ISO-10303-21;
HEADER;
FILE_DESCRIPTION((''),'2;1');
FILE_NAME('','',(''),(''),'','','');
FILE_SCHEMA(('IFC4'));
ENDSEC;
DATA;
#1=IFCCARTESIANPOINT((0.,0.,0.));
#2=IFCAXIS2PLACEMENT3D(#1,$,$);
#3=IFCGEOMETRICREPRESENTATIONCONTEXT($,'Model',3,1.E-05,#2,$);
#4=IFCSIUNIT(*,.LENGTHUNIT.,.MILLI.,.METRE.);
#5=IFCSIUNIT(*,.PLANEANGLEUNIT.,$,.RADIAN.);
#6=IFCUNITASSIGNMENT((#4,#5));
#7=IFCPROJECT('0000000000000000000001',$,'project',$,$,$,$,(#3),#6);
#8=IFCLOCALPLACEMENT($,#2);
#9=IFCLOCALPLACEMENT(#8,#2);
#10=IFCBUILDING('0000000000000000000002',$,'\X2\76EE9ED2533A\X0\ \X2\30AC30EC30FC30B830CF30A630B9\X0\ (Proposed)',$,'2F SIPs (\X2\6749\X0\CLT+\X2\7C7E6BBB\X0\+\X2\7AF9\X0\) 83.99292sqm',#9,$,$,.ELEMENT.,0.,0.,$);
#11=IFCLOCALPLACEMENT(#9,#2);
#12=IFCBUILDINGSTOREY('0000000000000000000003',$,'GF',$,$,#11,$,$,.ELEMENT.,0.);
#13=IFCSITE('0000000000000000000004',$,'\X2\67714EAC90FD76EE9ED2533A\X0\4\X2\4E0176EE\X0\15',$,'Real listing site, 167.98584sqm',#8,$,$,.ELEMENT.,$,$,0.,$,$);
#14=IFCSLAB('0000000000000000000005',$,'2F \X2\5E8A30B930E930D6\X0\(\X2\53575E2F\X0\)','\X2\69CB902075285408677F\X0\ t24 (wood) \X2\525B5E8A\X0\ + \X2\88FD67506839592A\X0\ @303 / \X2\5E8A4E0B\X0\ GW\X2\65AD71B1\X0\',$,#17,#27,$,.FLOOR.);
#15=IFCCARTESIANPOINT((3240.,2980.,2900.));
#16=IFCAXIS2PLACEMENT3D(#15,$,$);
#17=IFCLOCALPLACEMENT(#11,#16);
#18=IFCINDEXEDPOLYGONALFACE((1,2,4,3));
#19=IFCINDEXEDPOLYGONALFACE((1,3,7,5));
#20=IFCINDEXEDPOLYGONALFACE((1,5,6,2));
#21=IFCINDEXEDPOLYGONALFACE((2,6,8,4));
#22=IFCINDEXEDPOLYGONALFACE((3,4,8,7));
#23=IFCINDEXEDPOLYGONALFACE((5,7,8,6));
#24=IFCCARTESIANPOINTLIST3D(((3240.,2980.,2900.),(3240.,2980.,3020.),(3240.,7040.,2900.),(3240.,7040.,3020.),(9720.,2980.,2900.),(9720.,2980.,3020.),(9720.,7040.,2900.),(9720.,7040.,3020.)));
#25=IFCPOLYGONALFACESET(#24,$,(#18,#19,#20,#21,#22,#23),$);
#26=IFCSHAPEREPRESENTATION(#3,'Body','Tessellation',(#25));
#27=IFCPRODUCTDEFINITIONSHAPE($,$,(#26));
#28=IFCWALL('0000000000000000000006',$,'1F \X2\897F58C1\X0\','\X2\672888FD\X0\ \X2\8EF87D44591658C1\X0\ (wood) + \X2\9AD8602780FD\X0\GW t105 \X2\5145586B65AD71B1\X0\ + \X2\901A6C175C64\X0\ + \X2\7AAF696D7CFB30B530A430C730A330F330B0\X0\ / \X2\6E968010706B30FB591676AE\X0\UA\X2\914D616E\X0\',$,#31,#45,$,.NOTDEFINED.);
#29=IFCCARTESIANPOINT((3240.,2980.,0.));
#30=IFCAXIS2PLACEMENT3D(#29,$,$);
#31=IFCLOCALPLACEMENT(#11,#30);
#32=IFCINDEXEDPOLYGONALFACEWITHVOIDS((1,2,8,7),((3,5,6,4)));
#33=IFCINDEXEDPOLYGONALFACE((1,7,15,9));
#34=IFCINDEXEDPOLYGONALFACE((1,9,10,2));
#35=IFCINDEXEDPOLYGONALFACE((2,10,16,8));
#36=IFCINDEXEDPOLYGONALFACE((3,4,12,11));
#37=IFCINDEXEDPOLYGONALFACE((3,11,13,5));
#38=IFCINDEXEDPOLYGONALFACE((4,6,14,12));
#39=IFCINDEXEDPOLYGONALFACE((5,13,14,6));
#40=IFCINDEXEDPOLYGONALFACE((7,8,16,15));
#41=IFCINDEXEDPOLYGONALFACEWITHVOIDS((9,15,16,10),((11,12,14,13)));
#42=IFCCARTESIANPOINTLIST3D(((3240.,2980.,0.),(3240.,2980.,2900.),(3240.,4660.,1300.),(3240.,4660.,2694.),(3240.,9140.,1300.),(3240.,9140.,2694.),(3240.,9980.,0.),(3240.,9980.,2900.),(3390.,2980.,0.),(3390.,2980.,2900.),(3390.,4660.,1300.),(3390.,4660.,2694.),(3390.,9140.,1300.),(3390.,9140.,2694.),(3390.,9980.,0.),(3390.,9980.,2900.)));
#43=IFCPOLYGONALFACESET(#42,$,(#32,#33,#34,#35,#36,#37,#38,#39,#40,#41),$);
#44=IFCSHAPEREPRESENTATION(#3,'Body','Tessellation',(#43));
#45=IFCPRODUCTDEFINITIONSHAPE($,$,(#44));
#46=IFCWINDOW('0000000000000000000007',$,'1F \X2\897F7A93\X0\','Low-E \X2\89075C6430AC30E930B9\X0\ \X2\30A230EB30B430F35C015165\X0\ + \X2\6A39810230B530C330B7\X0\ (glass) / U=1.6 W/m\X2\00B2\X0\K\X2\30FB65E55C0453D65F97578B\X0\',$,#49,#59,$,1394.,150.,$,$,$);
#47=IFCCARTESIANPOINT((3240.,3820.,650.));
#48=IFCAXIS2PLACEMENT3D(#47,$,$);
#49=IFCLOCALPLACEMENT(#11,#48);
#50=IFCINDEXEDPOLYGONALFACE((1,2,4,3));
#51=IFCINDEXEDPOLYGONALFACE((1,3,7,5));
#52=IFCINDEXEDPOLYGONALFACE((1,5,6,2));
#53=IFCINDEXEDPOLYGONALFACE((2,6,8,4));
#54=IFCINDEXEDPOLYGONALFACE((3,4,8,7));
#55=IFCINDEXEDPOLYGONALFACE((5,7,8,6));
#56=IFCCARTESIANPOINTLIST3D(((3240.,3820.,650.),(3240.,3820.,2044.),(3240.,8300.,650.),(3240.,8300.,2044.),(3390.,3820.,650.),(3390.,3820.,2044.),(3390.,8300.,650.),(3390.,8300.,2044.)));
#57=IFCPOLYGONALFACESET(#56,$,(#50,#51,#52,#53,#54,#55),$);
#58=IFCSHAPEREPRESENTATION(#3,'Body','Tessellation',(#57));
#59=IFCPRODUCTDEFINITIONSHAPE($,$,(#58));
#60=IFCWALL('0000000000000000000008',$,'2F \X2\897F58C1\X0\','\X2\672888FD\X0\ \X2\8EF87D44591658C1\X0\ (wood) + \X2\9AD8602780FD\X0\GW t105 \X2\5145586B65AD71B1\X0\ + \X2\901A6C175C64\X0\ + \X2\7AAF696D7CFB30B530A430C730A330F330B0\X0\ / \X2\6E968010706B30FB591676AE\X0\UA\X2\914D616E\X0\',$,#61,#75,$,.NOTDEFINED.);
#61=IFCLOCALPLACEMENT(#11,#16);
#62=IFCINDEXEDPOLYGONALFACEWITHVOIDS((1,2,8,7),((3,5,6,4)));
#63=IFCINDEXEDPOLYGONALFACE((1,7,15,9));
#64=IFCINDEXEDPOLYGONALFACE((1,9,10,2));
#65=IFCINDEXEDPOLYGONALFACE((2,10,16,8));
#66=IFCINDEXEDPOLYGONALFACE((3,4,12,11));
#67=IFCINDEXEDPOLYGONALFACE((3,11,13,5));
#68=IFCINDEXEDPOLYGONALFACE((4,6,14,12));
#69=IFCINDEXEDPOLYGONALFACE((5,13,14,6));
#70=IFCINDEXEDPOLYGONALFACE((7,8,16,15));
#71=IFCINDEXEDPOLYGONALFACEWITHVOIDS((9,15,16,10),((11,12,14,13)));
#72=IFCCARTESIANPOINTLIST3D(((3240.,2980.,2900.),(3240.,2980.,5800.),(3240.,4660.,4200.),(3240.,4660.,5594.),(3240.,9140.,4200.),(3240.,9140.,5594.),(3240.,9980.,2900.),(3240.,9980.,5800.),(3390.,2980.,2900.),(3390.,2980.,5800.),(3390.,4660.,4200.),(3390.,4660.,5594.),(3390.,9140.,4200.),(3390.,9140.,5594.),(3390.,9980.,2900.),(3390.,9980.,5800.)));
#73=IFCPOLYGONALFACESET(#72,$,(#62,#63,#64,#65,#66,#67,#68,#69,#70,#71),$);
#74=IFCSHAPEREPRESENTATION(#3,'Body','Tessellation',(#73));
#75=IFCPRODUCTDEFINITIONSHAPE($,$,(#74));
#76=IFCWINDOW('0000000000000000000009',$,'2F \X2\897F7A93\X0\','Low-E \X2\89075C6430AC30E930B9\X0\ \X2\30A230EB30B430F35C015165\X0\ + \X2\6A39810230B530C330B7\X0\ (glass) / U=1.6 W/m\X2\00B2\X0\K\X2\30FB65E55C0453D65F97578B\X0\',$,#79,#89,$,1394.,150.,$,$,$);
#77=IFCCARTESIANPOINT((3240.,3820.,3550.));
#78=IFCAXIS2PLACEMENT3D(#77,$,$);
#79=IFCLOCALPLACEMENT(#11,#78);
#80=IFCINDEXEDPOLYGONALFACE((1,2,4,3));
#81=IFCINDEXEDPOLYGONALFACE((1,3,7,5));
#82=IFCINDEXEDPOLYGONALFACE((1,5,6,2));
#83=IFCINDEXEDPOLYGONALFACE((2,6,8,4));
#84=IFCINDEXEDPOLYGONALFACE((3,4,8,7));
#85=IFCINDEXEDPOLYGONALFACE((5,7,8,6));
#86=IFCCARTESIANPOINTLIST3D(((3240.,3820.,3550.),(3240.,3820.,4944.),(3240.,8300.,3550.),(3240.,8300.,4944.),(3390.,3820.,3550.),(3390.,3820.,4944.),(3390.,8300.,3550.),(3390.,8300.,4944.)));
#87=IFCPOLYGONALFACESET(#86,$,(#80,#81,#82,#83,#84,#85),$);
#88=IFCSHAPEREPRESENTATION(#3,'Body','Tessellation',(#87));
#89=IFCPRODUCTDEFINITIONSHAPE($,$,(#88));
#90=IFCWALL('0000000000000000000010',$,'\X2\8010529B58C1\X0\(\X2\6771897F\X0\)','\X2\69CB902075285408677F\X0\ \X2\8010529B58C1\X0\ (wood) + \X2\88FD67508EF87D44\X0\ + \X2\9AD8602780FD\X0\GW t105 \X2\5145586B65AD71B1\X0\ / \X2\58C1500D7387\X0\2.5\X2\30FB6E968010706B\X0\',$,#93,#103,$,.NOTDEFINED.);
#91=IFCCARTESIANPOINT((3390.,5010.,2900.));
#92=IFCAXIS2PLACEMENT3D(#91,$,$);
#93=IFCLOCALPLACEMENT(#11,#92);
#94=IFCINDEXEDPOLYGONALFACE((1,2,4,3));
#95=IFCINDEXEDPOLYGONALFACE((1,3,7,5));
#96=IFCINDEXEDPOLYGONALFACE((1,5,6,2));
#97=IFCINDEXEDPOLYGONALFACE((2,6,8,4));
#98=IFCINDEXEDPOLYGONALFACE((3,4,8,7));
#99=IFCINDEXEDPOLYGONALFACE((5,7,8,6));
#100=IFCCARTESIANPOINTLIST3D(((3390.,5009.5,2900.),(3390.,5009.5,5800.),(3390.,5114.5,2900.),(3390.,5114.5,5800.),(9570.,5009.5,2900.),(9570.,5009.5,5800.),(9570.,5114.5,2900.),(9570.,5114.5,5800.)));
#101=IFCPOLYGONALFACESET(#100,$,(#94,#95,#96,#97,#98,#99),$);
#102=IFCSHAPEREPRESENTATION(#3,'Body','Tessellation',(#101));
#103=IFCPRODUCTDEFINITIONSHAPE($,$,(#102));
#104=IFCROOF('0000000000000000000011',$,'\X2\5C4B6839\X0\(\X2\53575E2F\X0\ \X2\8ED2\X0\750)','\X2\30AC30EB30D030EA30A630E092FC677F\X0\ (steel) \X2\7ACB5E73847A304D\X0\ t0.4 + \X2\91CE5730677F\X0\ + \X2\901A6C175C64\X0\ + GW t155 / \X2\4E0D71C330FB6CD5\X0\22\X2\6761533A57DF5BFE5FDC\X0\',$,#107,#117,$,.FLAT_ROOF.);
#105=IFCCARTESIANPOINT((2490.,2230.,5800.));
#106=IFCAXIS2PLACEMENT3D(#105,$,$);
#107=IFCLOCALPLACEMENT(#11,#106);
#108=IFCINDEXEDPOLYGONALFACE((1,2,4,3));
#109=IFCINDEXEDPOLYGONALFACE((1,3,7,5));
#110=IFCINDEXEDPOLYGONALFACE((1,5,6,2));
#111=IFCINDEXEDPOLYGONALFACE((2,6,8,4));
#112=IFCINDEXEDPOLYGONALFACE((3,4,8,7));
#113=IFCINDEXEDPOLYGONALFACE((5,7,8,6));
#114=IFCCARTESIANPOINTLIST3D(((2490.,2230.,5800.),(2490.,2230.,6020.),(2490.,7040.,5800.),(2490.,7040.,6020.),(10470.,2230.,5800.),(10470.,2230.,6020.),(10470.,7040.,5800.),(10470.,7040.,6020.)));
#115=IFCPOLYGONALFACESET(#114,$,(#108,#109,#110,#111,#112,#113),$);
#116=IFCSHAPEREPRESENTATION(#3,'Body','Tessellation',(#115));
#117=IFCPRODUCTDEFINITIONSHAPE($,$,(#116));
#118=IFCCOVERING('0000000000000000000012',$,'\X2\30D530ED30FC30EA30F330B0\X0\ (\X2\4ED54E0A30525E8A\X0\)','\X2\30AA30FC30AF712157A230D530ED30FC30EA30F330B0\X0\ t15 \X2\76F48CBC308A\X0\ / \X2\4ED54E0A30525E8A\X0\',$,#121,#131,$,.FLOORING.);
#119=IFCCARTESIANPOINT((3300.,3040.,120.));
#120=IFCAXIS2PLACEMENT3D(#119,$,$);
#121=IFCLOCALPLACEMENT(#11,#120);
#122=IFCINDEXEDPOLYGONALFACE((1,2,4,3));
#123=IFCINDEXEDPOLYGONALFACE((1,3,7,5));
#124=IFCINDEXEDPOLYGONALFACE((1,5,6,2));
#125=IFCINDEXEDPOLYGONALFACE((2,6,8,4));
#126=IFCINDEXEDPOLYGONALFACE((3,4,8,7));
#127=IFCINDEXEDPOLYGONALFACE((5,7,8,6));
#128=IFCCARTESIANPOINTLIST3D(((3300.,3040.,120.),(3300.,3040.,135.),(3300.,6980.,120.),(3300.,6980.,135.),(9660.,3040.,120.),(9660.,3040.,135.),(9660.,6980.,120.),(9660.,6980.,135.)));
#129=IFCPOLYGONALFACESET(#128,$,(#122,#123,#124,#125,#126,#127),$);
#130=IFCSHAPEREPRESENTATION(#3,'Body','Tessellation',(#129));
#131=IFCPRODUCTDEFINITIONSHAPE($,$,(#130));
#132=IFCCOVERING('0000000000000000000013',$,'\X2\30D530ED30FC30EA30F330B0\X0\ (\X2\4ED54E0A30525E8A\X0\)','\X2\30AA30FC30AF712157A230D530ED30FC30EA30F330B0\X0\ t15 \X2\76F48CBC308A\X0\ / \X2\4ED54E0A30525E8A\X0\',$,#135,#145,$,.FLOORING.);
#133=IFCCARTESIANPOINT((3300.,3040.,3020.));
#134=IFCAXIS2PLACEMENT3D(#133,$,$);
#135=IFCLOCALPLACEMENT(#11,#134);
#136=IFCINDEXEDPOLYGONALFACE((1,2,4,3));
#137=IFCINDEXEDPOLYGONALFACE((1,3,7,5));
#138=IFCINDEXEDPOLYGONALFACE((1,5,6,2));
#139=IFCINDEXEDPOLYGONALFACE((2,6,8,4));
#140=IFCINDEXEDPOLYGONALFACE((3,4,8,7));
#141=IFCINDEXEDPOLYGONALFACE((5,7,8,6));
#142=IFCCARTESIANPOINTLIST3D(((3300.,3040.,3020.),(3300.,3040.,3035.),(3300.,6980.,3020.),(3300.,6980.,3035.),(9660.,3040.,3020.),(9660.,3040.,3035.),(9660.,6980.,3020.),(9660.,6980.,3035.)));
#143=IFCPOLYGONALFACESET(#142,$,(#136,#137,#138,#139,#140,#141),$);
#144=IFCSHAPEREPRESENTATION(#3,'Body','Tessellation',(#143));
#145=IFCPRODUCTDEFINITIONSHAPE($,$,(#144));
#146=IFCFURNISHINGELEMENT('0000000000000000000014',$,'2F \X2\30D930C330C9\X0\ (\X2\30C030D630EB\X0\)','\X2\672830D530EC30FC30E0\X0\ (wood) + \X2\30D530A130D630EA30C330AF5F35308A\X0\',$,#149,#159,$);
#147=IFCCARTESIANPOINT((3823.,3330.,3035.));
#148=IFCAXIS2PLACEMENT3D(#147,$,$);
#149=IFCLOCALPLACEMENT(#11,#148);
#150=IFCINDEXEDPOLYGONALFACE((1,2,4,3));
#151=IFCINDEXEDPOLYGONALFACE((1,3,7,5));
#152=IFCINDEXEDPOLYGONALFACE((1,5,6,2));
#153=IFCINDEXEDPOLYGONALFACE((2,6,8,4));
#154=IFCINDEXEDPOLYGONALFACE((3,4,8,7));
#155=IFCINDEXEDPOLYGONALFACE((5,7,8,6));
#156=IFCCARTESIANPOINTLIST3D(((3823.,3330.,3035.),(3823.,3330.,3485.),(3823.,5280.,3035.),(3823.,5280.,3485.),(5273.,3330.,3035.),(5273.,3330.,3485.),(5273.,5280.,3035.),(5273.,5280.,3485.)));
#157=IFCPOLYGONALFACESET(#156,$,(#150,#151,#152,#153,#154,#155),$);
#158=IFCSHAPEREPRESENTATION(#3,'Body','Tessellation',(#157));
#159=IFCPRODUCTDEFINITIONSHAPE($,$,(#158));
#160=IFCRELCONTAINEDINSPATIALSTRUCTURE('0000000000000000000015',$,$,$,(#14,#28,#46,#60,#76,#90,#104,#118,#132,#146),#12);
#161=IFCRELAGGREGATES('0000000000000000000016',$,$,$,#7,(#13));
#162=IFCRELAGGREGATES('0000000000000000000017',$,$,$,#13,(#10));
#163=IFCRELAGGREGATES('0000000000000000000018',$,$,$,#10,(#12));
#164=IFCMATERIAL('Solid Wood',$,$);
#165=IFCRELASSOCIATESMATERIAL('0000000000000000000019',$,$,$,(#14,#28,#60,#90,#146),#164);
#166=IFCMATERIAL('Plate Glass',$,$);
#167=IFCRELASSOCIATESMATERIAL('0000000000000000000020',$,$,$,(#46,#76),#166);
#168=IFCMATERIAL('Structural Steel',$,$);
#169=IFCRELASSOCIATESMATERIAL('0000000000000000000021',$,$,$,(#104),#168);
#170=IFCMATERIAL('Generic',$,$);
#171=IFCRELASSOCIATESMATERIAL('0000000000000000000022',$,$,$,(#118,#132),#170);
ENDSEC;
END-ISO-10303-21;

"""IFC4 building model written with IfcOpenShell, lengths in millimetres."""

from ifc_helpers import new_model, si_unit, frame, frame_2d, origin, place, context, project, spatial, rectangle, extrude, material, element, fill, save


model = new_model("IFC4")

# Units and contexts
model_context = context("Model", 3, precision=1e-05, world=origin())
ifc_project = project(units=[si_unit("LENGTHUNIT", "METRE", prefix="MILLI"), si_unit("PLANEANGLEUNIT", "RADIAN")], contexts=[model_context])

# Site, building, storey
site_placement = place(None, origin())
site = spatial("IfcSite", under=ifc_project, at=site_placement, Name="東京都目黒区4丁目15", ObjectType="Real listing site, 167.98584sqm", CompositionType="ELEMENT", RefElevation=0.0)
building_placement = place(site_placement, origin())
building = spatial("IfcBuilding", under=site, at=building_placement, Name="目黒区 ガレージハウス (Proposed)", ObjectType="2F SIPs (杉CLT+籾殻+竹) 83.99292sqm", CompositionType="ELEMENT", ElevationOfRefHeight=0.0, ElevationOfTerrain=0.0)
storey_placement = place(building_placement, origin())
storey = spatial("IfcBuildingStorey", under=building, at=storey_placement, Name="GF", CompositionType="ELEMENT", Elevation=0.0)

# Slab
ifc_material_1 = material(Name="Solid Wood")
slab_1_placement = place(storey_placement, frame((3240.0, 2980.0, 2900.0)))
element("IfcSlab", 1, at=slab_1_placement, inside=storey, material=ifc_material_1, Name="2F 床スラブ(南帯)", Description="構造用合板 t24 (wood) 剛床 + 製材根太 @303 / 床下 GW断熱", PredefinedType="FLOOR", context=model_context, shape_type="SweptSolid", body=[
    extrude(rectangle(XDim=6480.0, YDim=4060.0, at=frame_2d((3240.0, 2030.0))), frame((3240.0, 2980.0, 2900.0)), (0.0, 0.0, 1.0), 120.0),
])

# Shared definitions
ifc_material_2 = material(Name="Plate Glass")

# Wall, opening, window
wall_1_placement = place(storey_placement, frame((3240.0, 2980.0, 0.0)))
wall_1 = element("IfcWall", 2, at=wall_1_placement, inside=storey, material=ifc_material_1, Name="1F 西壁", Description="木製 軸組外壁 (wood) + 高性能GW t105 充填断熱 + 通気層 + 窯業系サイディング / 準耐火・外皮UA配慮", PredefinedType="NOTDEFINED", context=model_context, shape_type="SweptSolid", body=[
    extrude(rectangle(XDim=150.0, YDim=7000.0, at=frame_2d((75.0, 3500.0))), frame((3240.0, 2980.0, 0.0)), (0.0, 0.0, 1.0), 2900.0),
])
opening_1_placement = place(storey_placement, frame((3240.0, 3820.0, 650.0)))
opening_1 = element("IfcOpeningElement", 3, at=opening_1_placement, cuts=wall_1, PredefinedType="NOTDEFINED", context=model_context, shape_type="SweptSolid", body=[
    extrude(rectangle(XDim=150.0, YDim=4480.0, at=frame_2d((75.0, 2240.0))), frame((3240.0, 3820.0, 650.0)), (0.0, 0.0, 1.0), 1394.0),
])
window_1_placement = place(storey_placement, frame((3240.0, 3820.0, 650.0)))
window_1 = element("IfcWindow", 4, at=window_1_placement, inside=storey, material=ifc_material_2, Name="1F 西窓", Description="Low-E 複層ガラス アルゴン封入 + 樹脂サッシ (glass) / U=1.6 W/m²K・日射取得型", OverallHeight=1394.0, OverallWidth=150.0, context=model_context, shape_type="SweptSolid", body=[
    extrude(rectangle(XDim=150.0, YDim=4480.0, at=frame_2d((75.0, 2240.0))), frame((3240.0, 3820.0, 650.0)), (0.0, 0.0, 1.0), 1394.0),
])
fill(opening_1, window_1)

# Wall, opening, window
wall_2_placement = place(storey_placement, frame((3240.0, 2980.0, 2900.0)))
wall_2 = element("IfcWall", 5, at=wall_2_placement, inside=storey, material=ifc_material_1, Name="2F 西壁", Description="木製 軸組外壁 (wood) + 高性能GW t105 充填断熱 + 通気層 + 窯業系サイディング / 準耐火・外皮UA配慮", PredefinedType="NOTDEFINED", context=model_context, shape_type="SweptSolid", body=[
    extrude(rectangle(XDim=150.0, YDim=7000.0, at=frame_2d((75.0, 3500.0))), frame((3240.0, 2980.0, 2900.0)), (0.0, 0.0, 1.0), 2900.0),
])
opening_2_placement = place(storey_placement, frame((3240.0, 3820.0, 3550.0)))
opening_2 = element("IfcOpeningElement", 6, at=opening_2_placement, cuts=wall_2, PredefinedType="NOTDEFINED", context=model_context, shape_type="SweptSolid", body=[
    extrude(rectangle(XDim=150.0, YDim=4480.0, at=frame_2d((75.0, 2240.0))), frame((3240.0, 3820.0, 3550.0)), (0.0, 0.0, 1.0), 1394.0),
])
window_2_placement = place(storey_placement, frame((3240.0, 3820.0, 3550.0)))
window_2 = element("IfcWindow", 7, at=window_2_placement, inside=storey, material=ifc_material_2, Name="2F 西窓", Description="Low-E 複層ガラス アルゴン封入 + 樹脂サッシ (glass) / U=1.6 W/m²K・日射取得型", OverallHeight=1394.0, OverallWidth=150.0, context=model_context, shape_type="SweptSolid", body=[
    extrude(rectangle(XDim=150.0, YDim=4480.0, at=frame_2d((75.0, 2240.0))), frame((3240.0, 3820.0, 3550.0)), (0.0, 0.0, 1.0), 1394.0),
])
fill(opening_2, window_2)

# Wall
wall_3_placement = place(storey_placement, frame((3390.0, 5010.0, 2900.0)))
element("IfcWall", 8, at=wall_3_placement, inside=storey, material=ifc_material_1, Name="耐力壁(東西)", Description="構造用合板 耐力壁 (wood) + 製材軸組 + 高性能GW t105 充填断熱 / 壁倍率2.5・準耐火", PredefinedType="NOTDEFINED", context=model_context, shape_type="SweptSolid", body=[
    extrude(rectangle(XDim=6180.0, YDim=105.0, at=frame_2d((3090.0, 52.0))), frame((3390.0, 5010.0, 2900.0)), (0.0, 0.0, 1.0), 2900.0),
])

# Roof
ifc_material_3 = material(Name="Structural Steel")
for number, where, name in (
    (9, (2490.0, 2230.0, 5800.0), "屋根(南帯 軒750)"),
):
    element("IfcRoof", number, at=place(storey_placement, frame(where)), inside=storey, material=ifc_material_3, Name=name, Description="ガルバリウム鋼板 (steel) 立平葺き t0.4 + 野地板 + 通気層 + GW t155 / 不燃・法22条区域対応", PredefinedType="FLAT_ROOF", context=model_context, shape_type="SweptSolid", body=[
        extrude(rectangle(XDim=7980.0, YDim=4810.0, at=frame_2d((3990.0, 2405.0))), frame((2490.0, 2230.0, 5800.0)), (0.0, 0.0, 1.0), 220.0),
    ])

# Coverings
ifc_material_4 = material(Name="Generic")
covering_1_placement = place(storey_placement, frame((3300.0, 3040.0, 120.0)))
element("IfcCovering", 10, at=covering_1_placement, inside=storey, material=ifc_material_4, Name="フローリング (仕上げ床)", Description="オーク無垢フローリング t15 直貼り / 仕上げ床", PredefinedType="FLOORING", context=model_context, shape_type="SweptSolid", body=[
    extrude(rectangle(XDim=6360.0, YDim=3940.0, at=frame_2d((3180.0, 1970.0))), frame((3300.0, 3040.0, 120.0)), (0.0, 0.0, 1.0), 15.0),
])
covering_2_placement = place(storey_placement, frame((3300.0, 3040.0, 3020.0)))
element("IfcCovering", 11, at=covering_2_placement, inside=storey, material=ifc_material_4, Name="フローリング (仕上げ床)", Description="オーク無垢フローリング t15 直貼り / 仕上げ床", PredefinedType="FLOORING", context=model_context, shape_type="SweptSolid", body=[
    extrude(rectangle(XDim=6360.0, YDim=3940.0, at=frame_2d((3180.0, 1970.0))), frame((3300.0, 3040.0, 3020.0)), (0.0, 0.0, 1.0), 15.0),
])

# Furnishing element
furnishing_placement = place(storey_placement, frame((3823.0, 3330.0, 3035.0)))
element("IfcFurnishingElement", 12, at=furnishing_placement, inside=storey, material=ifc_material_1, Name="2F ベッド (ダブル)", Description="木フレーム (wood) + ファブリック張り", context=model_context, shape_type="SweptSolid", body=[
    extrude(rectangle(XDim=1450.0, YDim=1950.0, at=frame_2d((725.0, 975.0))), frame((3823.0, 3330.0, 3035.0)), (0.0, 0.0, 1.0), 450.0),
])

save(model, "model.ifc")
